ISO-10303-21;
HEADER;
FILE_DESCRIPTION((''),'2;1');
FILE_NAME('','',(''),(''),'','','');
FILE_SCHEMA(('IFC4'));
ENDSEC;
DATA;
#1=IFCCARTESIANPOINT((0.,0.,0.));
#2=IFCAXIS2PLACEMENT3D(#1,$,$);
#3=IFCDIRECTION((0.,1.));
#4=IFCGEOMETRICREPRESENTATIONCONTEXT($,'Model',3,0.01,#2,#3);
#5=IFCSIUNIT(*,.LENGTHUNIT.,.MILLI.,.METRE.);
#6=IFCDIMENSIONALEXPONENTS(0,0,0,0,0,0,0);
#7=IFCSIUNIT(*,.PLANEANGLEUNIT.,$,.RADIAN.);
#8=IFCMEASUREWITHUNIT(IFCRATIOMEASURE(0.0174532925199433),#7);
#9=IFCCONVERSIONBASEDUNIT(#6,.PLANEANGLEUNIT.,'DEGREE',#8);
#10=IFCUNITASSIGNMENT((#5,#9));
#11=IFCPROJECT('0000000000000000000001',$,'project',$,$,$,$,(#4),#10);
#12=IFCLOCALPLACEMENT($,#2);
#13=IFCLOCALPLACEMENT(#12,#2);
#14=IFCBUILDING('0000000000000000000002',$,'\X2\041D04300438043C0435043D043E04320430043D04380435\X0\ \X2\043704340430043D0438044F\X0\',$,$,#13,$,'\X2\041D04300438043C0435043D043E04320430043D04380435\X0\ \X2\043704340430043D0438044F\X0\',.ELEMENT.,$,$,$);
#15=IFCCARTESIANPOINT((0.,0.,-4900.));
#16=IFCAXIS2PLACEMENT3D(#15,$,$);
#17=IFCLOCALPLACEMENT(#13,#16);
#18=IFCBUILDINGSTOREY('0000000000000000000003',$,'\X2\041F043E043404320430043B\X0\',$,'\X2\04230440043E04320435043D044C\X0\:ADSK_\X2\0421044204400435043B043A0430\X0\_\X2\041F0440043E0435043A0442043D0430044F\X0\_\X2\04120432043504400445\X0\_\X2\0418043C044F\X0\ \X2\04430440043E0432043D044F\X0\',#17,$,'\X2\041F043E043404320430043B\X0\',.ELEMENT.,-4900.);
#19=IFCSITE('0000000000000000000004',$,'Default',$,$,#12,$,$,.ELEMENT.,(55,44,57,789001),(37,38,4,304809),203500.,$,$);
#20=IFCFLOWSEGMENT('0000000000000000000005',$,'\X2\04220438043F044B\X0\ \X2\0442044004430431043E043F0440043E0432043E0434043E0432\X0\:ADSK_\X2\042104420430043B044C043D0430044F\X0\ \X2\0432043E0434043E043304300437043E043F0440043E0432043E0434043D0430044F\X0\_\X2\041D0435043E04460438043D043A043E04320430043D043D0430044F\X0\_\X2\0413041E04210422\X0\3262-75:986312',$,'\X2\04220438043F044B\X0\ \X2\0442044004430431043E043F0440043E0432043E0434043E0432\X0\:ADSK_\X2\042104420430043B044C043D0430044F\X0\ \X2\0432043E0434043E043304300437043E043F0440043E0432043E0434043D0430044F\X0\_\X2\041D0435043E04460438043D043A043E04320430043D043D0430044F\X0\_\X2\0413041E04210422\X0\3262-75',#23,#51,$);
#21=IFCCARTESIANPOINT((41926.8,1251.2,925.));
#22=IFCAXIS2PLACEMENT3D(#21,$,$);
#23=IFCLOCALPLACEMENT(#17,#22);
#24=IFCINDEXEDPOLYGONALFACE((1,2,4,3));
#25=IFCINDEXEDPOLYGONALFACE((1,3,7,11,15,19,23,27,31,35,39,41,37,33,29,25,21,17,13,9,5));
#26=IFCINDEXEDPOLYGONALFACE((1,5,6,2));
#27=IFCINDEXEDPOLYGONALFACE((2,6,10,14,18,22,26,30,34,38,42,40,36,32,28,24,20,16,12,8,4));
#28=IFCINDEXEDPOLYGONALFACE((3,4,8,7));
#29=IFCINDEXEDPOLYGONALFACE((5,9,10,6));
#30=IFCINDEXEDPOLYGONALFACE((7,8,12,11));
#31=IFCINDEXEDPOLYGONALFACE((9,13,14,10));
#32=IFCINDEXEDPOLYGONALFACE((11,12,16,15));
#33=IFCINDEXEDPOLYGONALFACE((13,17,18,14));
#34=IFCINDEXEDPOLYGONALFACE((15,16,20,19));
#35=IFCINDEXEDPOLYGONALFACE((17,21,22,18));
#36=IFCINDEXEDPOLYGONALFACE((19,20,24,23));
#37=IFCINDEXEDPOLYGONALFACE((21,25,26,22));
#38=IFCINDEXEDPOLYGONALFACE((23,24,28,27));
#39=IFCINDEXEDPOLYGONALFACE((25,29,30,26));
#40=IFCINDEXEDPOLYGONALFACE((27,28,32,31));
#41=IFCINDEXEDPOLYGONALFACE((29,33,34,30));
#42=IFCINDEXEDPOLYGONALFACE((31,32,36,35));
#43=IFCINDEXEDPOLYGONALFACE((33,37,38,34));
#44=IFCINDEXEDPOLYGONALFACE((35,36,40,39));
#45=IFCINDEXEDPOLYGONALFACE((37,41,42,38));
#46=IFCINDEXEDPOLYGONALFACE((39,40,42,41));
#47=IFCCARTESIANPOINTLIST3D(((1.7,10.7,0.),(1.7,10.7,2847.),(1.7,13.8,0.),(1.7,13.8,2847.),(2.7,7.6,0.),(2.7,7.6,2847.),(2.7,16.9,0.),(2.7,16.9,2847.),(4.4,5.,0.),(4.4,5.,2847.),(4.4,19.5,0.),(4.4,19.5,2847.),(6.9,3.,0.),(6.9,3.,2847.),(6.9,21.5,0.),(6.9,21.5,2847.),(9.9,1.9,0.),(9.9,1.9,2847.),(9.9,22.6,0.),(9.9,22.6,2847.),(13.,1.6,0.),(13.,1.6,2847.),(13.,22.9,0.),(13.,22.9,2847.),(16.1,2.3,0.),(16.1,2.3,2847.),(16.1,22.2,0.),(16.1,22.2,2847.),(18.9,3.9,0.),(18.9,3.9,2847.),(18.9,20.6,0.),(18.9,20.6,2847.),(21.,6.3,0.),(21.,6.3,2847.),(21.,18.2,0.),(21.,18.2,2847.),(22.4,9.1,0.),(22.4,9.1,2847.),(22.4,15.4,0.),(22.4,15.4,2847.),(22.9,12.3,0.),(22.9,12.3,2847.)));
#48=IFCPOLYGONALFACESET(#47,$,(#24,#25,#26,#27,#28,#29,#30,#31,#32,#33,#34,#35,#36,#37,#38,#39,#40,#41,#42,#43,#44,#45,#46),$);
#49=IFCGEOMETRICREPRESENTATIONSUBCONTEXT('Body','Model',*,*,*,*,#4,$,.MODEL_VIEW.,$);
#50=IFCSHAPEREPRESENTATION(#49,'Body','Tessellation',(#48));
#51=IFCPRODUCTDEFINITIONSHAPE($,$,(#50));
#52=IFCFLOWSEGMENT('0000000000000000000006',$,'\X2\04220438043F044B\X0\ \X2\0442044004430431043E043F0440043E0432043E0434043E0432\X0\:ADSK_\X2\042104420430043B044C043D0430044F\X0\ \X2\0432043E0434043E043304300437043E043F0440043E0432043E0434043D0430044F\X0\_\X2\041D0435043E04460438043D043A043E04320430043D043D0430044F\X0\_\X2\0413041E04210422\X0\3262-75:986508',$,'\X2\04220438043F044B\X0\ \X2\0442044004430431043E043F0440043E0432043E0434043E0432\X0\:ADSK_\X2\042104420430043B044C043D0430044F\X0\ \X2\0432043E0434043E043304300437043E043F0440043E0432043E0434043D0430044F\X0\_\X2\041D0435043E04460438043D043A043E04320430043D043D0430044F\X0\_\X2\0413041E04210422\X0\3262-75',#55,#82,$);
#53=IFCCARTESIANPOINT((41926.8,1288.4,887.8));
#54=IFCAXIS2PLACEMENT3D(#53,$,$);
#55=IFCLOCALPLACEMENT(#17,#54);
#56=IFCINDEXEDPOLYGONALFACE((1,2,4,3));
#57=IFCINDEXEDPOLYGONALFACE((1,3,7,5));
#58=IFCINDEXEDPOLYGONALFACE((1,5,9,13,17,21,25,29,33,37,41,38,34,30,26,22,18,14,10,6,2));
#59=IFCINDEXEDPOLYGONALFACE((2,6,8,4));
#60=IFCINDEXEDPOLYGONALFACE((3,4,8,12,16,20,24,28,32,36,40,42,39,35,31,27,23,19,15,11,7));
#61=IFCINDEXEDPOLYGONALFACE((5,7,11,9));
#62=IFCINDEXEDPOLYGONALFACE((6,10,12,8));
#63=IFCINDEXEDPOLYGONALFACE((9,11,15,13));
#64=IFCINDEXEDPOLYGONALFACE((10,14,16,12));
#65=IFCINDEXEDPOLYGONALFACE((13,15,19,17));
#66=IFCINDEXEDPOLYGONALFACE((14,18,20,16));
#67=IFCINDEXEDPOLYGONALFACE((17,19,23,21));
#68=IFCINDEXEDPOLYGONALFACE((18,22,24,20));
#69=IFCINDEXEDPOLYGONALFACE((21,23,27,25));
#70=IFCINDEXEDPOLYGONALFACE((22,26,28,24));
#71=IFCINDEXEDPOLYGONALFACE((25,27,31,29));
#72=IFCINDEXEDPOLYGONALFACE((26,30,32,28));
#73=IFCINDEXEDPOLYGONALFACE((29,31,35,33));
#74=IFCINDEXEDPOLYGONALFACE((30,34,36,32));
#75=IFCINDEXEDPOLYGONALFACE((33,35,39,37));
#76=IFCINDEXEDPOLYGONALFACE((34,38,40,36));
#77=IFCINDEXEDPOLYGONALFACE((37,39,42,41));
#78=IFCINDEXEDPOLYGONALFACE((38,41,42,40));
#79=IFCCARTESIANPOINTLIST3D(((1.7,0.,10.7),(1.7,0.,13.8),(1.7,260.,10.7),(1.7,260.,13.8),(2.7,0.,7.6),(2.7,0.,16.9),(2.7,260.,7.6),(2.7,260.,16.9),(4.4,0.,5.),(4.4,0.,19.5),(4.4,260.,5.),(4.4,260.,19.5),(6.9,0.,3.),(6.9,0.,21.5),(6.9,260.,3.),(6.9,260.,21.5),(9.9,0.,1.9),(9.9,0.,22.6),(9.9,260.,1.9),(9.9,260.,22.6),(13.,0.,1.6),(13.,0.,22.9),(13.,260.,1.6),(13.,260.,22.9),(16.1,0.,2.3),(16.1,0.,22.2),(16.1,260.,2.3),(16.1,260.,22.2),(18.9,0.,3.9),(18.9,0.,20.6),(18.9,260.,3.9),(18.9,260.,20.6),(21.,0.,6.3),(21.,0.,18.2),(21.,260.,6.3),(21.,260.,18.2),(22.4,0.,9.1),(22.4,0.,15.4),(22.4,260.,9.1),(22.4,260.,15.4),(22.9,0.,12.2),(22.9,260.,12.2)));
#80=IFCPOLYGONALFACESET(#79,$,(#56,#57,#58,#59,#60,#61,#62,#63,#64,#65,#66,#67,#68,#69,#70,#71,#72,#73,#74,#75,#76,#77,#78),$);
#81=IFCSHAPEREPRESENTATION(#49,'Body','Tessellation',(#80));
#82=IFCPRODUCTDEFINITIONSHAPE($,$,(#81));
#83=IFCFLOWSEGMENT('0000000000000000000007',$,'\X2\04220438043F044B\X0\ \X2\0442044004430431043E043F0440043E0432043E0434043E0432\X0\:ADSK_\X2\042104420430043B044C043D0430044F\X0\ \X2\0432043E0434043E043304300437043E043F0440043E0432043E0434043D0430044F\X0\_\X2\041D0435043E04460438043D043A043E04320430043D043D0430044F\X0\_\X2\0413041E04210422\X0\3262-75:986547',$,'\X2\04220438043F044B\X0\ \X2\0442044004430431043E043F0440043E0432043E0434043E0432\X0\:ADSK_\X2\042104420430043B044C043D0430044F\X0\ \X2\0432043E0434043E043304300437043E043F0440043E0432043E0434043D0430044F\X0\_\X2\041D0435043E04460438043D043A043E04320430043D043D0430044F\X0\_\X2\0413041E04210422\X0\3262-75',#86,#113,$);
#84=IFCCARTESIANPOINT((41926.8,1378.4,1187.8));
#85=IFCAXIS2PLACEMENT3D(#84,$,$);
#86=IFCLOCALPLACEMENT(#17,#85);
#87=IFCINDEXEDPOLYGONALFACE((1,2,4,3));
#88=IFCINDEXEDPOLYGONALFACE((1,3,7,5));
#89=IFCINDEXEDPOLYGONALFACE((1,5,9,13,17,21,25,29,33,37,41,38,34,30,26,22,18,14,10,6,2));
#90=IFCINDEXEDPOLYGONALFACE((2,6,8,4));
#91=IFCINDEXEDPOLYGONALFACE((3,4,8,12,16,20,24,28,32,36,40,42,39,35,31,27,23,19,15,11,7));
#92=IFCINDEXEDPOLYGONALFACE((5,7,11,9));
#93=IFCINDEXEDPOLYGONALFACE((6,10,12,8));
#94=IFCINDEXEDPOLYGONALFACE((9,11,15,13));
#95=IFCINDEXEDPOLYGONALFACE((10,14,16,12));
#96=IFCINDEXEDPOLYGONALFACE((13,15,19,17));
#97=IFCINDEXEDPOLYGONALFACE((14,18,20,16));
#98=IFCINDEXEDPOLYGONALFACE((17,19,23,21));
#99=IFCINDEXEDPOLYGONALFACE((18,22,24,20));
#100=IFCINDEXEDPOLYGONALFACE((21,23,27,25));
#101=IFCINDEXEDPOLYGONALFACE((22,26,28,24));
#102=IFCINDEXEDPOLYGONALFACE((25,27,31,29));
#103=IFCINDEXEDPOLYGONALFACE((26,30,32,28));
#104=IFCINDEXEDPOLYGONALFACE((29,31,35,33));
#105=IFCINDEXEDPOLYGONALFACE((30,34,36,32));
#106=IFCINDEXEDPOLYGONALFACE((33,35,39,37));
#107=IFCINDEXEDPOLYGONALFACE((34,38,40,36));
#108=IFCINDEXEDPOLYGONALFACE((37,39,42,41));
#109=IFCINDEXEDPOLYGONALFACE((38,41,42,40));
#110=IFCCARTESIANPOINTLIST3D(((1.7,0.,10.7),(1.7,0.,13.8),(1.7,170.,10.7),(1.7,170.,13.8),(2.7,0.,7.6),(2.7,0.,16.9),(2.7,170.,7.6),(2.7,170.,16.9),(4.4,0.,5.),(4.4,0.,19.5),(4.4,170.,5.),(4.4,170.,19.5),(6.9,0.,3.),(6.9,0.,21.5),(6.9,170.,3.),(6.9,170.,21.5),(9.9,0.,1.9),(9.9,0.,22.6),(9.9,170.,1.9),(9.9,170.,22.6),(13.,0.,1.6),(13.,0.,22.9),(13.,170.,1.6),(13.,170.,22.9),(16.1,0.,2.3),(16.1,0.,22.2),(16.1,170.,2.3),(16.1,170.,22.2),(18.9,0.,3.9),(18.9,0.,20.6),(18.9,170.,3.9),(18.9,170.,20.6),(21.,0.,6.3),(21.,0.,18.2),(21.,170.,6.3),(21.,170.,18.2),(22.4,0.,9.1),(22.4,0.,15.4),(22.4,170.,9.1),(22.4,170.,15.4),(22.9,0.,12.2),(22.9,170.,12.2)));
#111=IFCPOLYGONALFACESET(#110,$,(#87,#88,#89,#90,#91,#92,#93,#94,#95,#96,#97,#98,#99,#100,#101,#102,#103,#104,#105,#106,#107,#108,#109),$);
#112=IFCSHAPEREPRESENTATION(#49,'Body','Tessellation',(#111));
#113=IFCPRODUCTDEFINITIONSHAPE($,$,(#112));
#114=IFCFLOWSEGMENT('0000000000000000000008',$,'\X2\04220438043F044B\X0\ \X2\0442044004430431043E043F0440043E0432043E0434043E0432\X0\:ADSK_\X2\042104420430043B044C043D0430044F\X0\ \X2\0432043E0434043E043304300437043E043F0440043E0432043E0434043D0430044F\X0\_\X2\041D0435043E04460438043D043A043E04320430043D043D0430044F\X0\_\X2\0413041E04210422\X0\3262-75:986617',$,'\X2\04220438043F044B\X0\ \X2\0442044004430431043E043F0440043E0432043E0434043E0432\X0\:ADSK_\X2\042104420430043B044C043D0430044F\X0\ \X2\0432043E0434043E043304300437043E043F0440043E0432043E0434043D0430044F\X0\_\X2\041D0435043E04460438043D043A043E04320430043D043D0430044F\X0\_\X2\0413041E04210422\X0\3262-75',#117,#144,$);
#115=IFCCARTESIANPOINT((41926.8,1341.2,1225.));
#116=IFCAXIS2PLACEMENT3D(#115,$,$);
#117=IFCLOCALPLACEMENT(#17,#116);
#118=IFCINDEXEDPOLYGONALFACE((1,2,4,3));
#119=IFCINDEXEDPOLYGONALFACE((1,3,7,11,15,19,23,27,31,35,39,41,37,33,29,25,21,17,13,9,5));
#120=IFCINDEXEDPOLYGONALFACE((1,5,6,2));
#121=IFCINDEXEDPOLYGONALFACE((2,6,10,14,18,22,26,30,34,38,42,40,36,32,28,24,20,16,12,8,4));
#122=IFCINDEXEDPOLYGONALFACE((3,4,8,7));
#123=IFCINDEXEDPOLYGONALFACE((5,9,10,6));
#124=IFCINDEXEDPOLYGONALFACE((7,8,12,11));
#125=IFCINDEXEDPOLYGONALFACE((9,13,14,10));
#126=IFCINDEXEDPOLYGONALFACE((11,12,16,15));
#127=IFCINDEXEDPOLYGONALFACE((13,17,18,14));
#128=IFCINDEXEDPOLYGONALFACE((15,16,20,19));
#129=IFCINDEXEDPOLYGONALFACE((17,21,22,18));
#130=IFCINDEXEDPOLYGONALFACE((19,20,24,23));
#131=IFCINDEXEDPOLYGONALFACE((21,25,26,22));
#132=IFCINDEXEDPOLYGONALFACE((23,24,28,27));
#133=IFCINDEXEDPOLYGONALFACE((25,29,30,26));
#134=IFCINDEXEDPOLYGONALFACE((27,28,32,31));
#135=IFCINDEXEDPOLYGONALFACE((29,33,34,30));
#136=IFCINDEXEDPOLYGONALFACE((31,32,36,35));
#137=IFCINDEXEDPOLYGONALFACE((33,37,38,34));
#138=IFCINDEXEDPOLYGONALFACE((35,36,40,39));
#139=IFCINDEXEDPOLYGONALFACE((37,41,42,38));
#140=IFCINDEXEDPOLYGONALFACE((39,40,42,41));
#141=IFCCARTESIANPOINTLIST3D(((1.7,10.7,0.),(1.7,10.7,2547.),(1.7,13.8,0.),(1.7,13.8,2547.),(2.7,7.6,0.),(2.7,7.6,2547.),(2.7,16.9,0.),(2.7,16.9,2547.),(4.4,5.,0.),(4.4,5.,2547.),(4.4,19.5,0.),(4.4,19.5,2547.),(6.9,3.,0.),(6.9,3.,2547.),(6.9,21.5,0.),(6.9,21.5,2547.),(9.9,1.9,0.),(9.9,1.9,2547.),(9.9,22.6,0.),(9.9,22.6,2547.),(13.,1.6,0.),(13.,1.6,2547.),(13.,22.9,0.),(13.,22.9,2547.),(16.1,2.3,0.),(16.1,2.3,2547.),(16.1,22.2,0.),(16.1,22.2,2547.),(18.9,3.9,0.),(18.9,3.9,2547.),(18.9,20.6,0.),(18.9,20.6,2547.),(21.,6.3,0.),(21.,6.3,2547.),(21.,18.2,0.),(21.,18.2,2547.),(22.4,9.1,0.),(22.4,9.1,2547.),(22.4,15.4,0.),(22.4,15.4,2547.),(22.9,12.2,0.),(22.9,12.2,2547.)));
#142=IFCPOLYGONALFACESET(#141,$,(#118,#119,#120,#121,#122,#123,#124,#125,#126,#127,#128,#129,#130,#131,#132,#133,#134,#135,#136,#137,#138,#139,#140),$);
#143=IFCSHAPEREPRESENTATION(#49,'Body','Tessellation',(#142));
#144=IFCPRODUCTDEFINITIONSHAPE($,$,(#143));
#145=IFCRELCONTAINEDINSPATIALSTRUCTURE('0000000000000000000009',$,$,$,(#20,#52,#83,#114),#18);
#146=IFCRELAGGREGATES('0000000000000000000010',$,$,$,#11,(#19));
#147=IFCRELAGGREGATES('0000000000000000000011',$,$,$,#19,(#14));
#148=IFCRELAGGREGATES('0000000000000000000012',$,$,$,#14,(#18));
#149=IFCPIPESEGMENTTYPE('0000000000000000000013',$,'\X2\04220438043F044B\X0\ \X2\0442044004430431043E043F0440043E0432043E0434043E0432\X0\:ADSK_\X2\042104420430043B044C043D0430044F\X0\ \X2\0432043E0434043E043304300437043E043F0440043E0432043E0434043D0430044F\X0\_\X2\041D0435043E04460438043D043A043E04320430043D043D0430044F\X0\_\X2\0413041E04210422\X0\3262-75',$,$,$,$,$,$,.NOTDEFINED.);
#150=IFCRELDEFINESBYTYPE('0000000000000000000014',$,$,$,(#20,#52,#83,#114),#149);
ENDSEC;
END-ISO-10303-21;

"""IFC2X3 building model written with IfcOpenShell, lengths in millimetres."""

from ifc_helpers import new_model, entity, si_unit, converted_unit, direction, frame, origin, origin_2d_with_axis, place, context, subcontext, project, spatial, circle, extrude, type_object, element, save


model = new_model("IFC2X3")

# Units and contexts
model_context = context("Model", 3, precision=0.01, world=origin(), true_north=direction((0.0, 1.0)))
body_context = subcontext(model_context, "Body", "Model", "MODEL_VIEW")
ifc_project = project(units=[si_unit("LENGTHUNIT", "METRE", prefix="MILLI"), converted_unit("PLANEANGLEUNIT", "DEGREE", entity("IfcRatioMeasure", 0.0174532925199433), si_unit("PLANEANGLEUNIT", "RADIAN"), dimensions=[0, 0, 0, 0, 0, 0, 0])], contexts=[model_context])

# Site, building, storey
site_placement = place(None, origin())
site = spatial("IfcSite", under=ifc_project, at=site_placement, Name="Default", CompositionType="ELEMENT", RefLatitude=(55, 44, 57, 789001), RefLongitude=(37, 38, 4, 304809), RefElevation=203500.0)
building_placement = place(site_placement, origin())
building = spatial("IfcBuilding", under=site, at=building_placement, Name="Наименование здания", LongName="Наименование здания", CompositionType="ELEMENT")
storey_placement = place(building_placement, frame((0.0, 0.0, -4900.0)))
storey = spatial("IfcBuildingStorey", under=building, at=storey_placement, Name="Подвал", ObjectType="Уровень:ADSK_Стрелка_Проектная_Вверх_Имя уровня", LongName="Подвал", CompositionType="ELEMENT", Elevation=-4900.0)

# Flow segments
pipe_segment_type = type_object("IfcPipeSegmentType", Name="Типы трубопроводов:ADSK_Стальная водогазопроводная_Неоцинкованная_ГОСТ3262-75", PredefinedType="NOTDEFINED")
flow_segment_1_placement = place(storey_placement, frame((41926.8, 1251.2, 925.0)))
element("IfcFlowSegment", 1, at=flow_segment_1_placement, inside=storey, type_object=pipe_segment_type, Name="Типы трубопроводов:ADSK_Стальная водогазопроводная_Неоцинкованная_ГОСТ3262-75:986312", ObjectType="Типы трубопроводов:ADSK_Стальная водогазопроводная_Неоцинкованная_ГОСТ3262-75", context=body_context, shape_type="SweptSolid", body=[
    extrude(circle(Radius=10.7, at=origin_2d_with_axis()), frame((12.2, 12.2, 0.0)), (0.0, 0.0, 1.0), 2847.0),
])
flow_segment_2_placement = place(storey_placement, frame((41926.8, 1288.4, 887.8)))
element("IfcFlowSegment", 2, at=flow_segment_2_placement, inside=storey, type_object=pipe_segment_type, Name="Типы трубопроводов:ADSK_Стальная водогазопроводная_Неоцинкованная_ГОСТ3262-75:986508", ObjectType="Типы трубопроводов:ADSK_Стальная водогазопроводная_Неоцинкованная_ГОСТ3262-75", context=body_context, shape_type="SweptSolid", body=[
    extrude(circle(Radius=10.7, at=origin_2d_with_axis()), frame((12.2, 0.0, 12.2), z_axis=(0.0, 1.0, 0.0), x_axis=(1.0, 0.0, 0.0)), (0.0, 0.0, 1.0), 260.0),
])
flow_segment_3_placement = place(storey_placement, frame((41926.8, 1378.4, 1187.8)))
element("IfcFlowSegment", 3, at=flow_segment_3_placement, inside=storey, type_object=pipe_segment_type, Name="Типы трубопроводов:ADSK_Стальная водогазопроводная_Неоцинкованная_ГОСТ3262-75:986547", ObjectType="Типы трубопроводов:ADSK_Стальная водогазопроводная_Неоцинкованная_ГОСТ3262-75", context=body_context, shape_type="SweptSolid", body=[
    extrude(circle(Radius=10.7, at=origin_2d_with_axis()), frame((12.2, 0.0, 12.2), z_axis=(0.0, 1.0, 0.0), x_axis=(1.0, 0.0, 0.0)), (0.0, 0.0, 1.0), 170.0),
])
flow_segment_4_placement = place(storey_placement, frame((41926.8, 1341.2, 1225.0)))
element("IfcFlowSegment", 4, at=flow_segment_4_placement, inside=storey, type_object=pipe_segment_type, Name="Типы трубопроводов:ADSK_Стальная водогазопроводная_Неоцинкованная_ГОСТ3262-75:986617", ObjectType="Типы трубопроводов:ADSK_Стальная водогазопроводная_Неоцинкованная_ГОСТ3262-75", context=body_context, shape_type="SweptSolid", body=[
    extrude(circle(Radius=10.7, at=origin_2d_with_axis()), frame((12.2, 12.2, 0.0)), (0.0, 0.0, 1.0), 2547.0),
])

save(model, "model.ifc")
